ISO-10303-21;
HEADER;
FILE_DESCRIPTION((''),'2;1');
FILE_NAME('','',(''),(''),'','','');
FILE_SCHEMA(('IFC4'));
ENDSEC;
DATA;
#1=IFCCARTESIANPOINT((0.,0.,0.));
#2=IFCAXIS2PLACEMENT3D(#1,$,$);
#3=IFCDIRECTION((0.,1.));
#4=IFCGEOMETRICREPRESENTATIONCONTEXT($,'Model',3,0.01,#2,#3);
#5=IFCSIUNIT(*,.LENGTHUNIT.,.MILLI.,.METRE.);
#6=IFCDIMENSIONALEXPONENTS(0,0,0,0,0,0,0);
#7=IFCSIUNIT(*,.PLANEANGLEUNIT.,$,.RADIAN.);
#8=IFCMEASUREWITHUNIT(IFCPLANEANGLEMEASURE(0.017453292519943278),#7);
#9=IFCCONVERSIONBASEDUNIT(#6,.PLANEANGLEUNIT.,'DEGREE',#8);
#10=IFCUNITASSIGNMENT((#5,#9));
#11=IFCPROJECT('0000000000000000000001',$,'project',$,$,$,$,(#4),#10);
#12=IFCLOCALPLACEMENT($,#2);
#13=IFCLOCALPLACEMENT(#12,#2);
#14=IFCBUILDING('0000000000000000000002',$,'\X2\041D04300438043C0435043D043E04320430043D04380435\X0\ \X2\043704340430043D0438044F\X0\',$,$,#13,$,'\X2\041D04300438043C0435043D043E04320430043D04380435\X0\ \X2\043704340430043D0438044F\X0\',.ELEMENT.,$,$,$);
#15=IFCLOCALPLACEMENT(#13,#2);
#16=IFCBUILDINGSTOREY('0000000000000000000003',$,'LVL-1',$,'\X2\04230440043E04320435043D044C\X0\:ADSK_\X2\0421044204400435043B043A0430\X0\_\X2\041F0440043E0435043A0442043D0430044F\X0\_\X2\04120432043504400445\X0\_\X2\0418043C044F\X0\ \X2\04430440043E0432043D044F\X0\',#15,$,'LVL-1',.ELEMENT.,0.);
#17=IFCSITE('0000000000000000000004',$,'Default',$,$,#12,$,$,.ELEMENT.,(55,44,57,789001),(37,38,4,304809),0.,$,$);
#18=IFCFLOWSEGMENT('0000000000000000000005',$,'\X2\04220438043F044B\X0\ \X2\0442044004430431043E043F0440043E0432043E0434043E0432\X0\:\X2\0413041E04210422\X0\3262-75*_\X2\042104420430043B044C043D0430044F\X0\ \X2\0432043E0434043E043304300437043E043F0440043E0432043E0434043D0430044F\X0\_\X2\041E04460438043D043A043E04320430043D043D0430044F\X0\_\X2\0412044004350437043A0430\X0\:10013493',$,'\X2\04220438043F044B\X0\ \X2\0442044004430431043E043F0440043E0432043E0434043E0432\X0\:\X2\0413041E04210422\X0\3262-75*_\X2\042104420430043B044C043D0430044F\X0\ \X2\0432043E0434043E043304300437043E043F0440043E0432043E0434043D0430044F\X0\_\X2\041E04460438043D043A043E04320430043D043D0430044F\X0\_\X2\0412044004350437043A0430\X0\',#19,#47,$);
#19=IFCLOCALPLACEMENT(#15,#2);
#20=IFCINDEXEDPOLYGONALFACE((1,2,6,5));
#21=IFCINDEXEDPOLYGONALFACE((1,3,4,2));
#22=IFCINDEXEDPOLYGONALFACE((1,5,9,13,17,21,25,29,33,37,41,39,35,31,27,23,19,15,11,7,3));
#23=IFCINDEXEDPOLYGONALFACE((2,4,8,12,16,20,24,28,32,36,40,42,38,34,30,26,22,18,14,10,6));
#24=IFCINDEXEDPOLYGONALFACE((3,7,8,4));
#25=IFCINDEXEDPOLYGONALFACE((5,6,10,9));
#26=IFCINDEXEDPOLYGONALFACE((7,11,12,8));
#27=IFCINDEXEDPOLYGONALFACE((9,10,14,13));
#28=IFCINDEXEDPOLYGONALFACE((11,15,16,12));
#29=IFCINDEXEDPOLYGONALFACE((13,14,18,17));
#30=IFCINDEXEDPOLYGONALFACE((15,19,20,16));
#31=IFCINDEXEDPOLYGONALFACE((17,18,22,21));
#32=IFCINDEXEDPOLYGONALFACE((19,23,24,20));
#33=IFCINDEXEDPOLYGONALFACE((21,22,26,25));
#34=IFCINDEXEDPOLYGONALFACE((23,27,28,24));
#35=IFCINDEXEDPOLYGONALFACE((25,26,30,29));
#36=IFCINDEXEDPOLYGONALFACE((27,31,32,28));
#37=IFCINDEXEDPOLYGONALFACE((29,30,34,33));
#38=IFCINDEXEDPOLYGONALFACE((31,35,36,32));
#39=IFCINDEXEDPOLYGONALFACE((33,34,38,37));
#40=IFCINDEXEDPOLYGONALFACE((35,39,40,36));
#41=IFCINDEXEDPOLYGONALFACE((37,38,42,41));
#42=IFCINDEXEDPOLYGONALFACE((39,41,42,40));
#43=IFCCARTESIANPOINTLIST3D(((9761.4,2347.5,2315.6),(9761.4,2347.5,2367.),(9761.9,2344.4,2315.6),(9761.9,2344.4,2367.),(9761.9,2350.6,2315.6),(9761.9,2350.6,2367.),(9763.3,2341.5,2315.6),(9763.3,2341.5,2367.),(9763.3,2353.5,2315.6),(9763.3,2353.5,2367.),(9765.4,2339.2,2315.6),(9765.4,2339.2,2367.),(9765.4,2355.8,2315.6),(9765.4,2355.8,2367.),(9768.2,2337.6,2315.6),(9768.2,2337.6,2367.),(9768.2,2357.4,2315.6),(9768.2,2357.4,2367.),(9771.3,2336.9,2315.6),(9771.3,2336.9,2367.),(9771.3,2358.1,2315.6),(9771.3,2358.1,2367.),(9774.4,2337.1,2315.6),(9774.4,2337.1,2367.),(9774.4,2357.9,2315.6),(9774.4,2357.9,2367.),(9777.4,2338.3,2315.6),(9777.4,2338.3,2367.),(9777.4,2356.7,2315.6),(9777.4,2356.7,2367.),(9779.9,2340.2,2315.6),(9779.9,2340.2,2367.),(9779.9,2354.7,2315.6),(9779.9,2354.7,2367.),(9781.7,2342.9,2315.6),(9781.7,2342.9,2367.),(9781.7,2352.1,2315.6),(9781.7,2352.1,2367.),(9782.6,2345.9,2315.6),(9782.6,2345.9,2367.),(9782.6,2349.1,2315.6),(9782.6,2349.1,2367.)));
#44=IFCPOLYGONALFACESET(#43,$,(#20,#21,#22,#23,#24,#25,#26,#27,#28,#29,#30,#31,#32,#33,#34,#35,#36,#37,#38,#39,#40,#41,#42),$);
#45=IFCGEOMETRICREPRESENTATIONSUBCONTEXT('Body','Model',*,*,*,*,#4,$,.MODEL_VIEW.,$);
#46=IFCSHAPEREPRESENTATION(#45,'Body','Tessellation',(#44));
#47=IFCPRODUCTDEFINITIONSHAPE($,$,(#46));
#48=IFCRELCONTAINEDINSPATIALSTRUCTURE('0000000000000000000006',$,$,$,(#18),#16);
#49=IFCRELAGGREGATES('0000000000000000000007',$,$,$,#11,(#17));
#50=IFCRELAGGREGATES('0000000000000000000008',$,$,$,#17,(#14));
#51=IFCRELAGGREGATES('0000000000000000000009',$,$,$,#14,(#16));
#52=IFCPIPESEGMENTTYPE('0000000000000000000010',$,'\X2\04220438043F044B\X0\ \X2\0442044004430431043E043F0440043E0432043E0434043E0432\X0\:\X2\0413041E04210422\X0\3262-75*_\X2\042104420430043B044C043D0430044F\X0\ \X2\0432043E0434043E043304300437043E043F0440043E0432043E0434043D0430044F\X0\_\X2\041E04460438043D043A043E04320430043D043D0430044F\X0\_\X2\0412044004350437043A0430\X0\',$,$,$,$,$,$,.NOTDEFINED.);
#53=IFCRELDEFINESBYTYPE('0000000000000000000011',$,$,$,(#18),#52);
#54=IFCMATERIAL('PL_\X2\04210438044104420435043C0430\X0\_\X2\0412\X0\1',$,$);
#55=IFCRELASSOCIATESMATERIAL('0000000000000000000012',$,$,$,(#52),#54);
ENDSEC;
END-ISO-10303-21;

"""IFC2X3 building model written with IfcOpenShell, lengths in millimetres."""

from ifc_helpers import new_model, entity, si_unit, converted_unit, direction, frame, origin, origin_2d_with_axis, place, context, subcontext, project, spatial, circle, extrude, material, type_object, element, save


model = new_model("IFC2X3")

# Units and contexts
model_context = context("Model", 3, precision=0.01, world=origin(), true_north=direction((0.0, 1.0)))
body_context = subcontext(model_context, "Body", "Model", "MODEL_VIEW")
ifc_project = project(units=[si_unit("LENGTHUNIT", "METRE", prefix="MILLI"), converted_unit("PLANEANGLEUNIT", "DEGREE", entity("IfcPlaneAngleMeasure", 0.017453292519943278), si_unit("PLANEANGLEUNIT", "RADIAN"), dimensions=[0, 0, 0, 0, 0, 0, 0])], contexts=[model_context])

# Site, building, storey
site_placement = place(None, origin())
site = spatial("IfcSite", under=ifc_project, at=site_placement, Name="Default", CompositionType="ELEMENT", RefLatitude=(55, 44, 57, 789001), RefLongitude=(37, 38, 4, 304809), RefElevation=0.0)
building_placement = place(site_placement, origin())
building = spatial("IfcBuilding", under=site, at=building_placement, Name="Наименование здания", LongName="Наименование здания", CompositionType="ELEMENT")
storey_placement = place(building_placement, origin())
storey = spatial("IfcBuildingStorey", under=building, at=storey_placement, Name="LVL-1", ObjectType="Уровень:ADSK_Стрелка_Проектная_Вверх_Имя уровня", LongName="LVL-1", CompositionType="ELEMENT", Elevation=0.0)

# Flow segment
ifc_material_1 = material(Name="PL_Система_В1")
pipe_segment_type_1 = type_object("IfcPipeSegmentType", Name="Типы трубопроводов:ГОСТ3262-75*_Стальная водогазопроводная_Оцинкованная_Врезка", PredefinedType="NOTDEFINED", material=ifc_material_1)
flow_segment_1_placement = place(storey_placement, origin())
element("IfcFlowSegment", 1, at=flow_segment_1_placement, inside=storey, type_object=pipe_segment_type_1, Name="Типы трубопроводов:ГОСТ3262-75*_Стальная водогазопроводная_Оцинкованная_Врезка:10013493", ObjectType="Типы трубопроводов:ГОСТ3262-75*_Стальная водогазопроводная_Оцинкованная_Врезка", context=body_context, shape_type="SweptSolid", body=[
    extrude(circle(Radius=10.7, at=origin_2d_with_axis()), frame((9772.1, 2347.5, 2315.6), z_axis=(0.0, 0.0, 1.0), x_axis=(-1.0, 0.0, 0.0)), (0.0, 0.0, 1.0), 51.4),
])

save(model, "model.ifc")
